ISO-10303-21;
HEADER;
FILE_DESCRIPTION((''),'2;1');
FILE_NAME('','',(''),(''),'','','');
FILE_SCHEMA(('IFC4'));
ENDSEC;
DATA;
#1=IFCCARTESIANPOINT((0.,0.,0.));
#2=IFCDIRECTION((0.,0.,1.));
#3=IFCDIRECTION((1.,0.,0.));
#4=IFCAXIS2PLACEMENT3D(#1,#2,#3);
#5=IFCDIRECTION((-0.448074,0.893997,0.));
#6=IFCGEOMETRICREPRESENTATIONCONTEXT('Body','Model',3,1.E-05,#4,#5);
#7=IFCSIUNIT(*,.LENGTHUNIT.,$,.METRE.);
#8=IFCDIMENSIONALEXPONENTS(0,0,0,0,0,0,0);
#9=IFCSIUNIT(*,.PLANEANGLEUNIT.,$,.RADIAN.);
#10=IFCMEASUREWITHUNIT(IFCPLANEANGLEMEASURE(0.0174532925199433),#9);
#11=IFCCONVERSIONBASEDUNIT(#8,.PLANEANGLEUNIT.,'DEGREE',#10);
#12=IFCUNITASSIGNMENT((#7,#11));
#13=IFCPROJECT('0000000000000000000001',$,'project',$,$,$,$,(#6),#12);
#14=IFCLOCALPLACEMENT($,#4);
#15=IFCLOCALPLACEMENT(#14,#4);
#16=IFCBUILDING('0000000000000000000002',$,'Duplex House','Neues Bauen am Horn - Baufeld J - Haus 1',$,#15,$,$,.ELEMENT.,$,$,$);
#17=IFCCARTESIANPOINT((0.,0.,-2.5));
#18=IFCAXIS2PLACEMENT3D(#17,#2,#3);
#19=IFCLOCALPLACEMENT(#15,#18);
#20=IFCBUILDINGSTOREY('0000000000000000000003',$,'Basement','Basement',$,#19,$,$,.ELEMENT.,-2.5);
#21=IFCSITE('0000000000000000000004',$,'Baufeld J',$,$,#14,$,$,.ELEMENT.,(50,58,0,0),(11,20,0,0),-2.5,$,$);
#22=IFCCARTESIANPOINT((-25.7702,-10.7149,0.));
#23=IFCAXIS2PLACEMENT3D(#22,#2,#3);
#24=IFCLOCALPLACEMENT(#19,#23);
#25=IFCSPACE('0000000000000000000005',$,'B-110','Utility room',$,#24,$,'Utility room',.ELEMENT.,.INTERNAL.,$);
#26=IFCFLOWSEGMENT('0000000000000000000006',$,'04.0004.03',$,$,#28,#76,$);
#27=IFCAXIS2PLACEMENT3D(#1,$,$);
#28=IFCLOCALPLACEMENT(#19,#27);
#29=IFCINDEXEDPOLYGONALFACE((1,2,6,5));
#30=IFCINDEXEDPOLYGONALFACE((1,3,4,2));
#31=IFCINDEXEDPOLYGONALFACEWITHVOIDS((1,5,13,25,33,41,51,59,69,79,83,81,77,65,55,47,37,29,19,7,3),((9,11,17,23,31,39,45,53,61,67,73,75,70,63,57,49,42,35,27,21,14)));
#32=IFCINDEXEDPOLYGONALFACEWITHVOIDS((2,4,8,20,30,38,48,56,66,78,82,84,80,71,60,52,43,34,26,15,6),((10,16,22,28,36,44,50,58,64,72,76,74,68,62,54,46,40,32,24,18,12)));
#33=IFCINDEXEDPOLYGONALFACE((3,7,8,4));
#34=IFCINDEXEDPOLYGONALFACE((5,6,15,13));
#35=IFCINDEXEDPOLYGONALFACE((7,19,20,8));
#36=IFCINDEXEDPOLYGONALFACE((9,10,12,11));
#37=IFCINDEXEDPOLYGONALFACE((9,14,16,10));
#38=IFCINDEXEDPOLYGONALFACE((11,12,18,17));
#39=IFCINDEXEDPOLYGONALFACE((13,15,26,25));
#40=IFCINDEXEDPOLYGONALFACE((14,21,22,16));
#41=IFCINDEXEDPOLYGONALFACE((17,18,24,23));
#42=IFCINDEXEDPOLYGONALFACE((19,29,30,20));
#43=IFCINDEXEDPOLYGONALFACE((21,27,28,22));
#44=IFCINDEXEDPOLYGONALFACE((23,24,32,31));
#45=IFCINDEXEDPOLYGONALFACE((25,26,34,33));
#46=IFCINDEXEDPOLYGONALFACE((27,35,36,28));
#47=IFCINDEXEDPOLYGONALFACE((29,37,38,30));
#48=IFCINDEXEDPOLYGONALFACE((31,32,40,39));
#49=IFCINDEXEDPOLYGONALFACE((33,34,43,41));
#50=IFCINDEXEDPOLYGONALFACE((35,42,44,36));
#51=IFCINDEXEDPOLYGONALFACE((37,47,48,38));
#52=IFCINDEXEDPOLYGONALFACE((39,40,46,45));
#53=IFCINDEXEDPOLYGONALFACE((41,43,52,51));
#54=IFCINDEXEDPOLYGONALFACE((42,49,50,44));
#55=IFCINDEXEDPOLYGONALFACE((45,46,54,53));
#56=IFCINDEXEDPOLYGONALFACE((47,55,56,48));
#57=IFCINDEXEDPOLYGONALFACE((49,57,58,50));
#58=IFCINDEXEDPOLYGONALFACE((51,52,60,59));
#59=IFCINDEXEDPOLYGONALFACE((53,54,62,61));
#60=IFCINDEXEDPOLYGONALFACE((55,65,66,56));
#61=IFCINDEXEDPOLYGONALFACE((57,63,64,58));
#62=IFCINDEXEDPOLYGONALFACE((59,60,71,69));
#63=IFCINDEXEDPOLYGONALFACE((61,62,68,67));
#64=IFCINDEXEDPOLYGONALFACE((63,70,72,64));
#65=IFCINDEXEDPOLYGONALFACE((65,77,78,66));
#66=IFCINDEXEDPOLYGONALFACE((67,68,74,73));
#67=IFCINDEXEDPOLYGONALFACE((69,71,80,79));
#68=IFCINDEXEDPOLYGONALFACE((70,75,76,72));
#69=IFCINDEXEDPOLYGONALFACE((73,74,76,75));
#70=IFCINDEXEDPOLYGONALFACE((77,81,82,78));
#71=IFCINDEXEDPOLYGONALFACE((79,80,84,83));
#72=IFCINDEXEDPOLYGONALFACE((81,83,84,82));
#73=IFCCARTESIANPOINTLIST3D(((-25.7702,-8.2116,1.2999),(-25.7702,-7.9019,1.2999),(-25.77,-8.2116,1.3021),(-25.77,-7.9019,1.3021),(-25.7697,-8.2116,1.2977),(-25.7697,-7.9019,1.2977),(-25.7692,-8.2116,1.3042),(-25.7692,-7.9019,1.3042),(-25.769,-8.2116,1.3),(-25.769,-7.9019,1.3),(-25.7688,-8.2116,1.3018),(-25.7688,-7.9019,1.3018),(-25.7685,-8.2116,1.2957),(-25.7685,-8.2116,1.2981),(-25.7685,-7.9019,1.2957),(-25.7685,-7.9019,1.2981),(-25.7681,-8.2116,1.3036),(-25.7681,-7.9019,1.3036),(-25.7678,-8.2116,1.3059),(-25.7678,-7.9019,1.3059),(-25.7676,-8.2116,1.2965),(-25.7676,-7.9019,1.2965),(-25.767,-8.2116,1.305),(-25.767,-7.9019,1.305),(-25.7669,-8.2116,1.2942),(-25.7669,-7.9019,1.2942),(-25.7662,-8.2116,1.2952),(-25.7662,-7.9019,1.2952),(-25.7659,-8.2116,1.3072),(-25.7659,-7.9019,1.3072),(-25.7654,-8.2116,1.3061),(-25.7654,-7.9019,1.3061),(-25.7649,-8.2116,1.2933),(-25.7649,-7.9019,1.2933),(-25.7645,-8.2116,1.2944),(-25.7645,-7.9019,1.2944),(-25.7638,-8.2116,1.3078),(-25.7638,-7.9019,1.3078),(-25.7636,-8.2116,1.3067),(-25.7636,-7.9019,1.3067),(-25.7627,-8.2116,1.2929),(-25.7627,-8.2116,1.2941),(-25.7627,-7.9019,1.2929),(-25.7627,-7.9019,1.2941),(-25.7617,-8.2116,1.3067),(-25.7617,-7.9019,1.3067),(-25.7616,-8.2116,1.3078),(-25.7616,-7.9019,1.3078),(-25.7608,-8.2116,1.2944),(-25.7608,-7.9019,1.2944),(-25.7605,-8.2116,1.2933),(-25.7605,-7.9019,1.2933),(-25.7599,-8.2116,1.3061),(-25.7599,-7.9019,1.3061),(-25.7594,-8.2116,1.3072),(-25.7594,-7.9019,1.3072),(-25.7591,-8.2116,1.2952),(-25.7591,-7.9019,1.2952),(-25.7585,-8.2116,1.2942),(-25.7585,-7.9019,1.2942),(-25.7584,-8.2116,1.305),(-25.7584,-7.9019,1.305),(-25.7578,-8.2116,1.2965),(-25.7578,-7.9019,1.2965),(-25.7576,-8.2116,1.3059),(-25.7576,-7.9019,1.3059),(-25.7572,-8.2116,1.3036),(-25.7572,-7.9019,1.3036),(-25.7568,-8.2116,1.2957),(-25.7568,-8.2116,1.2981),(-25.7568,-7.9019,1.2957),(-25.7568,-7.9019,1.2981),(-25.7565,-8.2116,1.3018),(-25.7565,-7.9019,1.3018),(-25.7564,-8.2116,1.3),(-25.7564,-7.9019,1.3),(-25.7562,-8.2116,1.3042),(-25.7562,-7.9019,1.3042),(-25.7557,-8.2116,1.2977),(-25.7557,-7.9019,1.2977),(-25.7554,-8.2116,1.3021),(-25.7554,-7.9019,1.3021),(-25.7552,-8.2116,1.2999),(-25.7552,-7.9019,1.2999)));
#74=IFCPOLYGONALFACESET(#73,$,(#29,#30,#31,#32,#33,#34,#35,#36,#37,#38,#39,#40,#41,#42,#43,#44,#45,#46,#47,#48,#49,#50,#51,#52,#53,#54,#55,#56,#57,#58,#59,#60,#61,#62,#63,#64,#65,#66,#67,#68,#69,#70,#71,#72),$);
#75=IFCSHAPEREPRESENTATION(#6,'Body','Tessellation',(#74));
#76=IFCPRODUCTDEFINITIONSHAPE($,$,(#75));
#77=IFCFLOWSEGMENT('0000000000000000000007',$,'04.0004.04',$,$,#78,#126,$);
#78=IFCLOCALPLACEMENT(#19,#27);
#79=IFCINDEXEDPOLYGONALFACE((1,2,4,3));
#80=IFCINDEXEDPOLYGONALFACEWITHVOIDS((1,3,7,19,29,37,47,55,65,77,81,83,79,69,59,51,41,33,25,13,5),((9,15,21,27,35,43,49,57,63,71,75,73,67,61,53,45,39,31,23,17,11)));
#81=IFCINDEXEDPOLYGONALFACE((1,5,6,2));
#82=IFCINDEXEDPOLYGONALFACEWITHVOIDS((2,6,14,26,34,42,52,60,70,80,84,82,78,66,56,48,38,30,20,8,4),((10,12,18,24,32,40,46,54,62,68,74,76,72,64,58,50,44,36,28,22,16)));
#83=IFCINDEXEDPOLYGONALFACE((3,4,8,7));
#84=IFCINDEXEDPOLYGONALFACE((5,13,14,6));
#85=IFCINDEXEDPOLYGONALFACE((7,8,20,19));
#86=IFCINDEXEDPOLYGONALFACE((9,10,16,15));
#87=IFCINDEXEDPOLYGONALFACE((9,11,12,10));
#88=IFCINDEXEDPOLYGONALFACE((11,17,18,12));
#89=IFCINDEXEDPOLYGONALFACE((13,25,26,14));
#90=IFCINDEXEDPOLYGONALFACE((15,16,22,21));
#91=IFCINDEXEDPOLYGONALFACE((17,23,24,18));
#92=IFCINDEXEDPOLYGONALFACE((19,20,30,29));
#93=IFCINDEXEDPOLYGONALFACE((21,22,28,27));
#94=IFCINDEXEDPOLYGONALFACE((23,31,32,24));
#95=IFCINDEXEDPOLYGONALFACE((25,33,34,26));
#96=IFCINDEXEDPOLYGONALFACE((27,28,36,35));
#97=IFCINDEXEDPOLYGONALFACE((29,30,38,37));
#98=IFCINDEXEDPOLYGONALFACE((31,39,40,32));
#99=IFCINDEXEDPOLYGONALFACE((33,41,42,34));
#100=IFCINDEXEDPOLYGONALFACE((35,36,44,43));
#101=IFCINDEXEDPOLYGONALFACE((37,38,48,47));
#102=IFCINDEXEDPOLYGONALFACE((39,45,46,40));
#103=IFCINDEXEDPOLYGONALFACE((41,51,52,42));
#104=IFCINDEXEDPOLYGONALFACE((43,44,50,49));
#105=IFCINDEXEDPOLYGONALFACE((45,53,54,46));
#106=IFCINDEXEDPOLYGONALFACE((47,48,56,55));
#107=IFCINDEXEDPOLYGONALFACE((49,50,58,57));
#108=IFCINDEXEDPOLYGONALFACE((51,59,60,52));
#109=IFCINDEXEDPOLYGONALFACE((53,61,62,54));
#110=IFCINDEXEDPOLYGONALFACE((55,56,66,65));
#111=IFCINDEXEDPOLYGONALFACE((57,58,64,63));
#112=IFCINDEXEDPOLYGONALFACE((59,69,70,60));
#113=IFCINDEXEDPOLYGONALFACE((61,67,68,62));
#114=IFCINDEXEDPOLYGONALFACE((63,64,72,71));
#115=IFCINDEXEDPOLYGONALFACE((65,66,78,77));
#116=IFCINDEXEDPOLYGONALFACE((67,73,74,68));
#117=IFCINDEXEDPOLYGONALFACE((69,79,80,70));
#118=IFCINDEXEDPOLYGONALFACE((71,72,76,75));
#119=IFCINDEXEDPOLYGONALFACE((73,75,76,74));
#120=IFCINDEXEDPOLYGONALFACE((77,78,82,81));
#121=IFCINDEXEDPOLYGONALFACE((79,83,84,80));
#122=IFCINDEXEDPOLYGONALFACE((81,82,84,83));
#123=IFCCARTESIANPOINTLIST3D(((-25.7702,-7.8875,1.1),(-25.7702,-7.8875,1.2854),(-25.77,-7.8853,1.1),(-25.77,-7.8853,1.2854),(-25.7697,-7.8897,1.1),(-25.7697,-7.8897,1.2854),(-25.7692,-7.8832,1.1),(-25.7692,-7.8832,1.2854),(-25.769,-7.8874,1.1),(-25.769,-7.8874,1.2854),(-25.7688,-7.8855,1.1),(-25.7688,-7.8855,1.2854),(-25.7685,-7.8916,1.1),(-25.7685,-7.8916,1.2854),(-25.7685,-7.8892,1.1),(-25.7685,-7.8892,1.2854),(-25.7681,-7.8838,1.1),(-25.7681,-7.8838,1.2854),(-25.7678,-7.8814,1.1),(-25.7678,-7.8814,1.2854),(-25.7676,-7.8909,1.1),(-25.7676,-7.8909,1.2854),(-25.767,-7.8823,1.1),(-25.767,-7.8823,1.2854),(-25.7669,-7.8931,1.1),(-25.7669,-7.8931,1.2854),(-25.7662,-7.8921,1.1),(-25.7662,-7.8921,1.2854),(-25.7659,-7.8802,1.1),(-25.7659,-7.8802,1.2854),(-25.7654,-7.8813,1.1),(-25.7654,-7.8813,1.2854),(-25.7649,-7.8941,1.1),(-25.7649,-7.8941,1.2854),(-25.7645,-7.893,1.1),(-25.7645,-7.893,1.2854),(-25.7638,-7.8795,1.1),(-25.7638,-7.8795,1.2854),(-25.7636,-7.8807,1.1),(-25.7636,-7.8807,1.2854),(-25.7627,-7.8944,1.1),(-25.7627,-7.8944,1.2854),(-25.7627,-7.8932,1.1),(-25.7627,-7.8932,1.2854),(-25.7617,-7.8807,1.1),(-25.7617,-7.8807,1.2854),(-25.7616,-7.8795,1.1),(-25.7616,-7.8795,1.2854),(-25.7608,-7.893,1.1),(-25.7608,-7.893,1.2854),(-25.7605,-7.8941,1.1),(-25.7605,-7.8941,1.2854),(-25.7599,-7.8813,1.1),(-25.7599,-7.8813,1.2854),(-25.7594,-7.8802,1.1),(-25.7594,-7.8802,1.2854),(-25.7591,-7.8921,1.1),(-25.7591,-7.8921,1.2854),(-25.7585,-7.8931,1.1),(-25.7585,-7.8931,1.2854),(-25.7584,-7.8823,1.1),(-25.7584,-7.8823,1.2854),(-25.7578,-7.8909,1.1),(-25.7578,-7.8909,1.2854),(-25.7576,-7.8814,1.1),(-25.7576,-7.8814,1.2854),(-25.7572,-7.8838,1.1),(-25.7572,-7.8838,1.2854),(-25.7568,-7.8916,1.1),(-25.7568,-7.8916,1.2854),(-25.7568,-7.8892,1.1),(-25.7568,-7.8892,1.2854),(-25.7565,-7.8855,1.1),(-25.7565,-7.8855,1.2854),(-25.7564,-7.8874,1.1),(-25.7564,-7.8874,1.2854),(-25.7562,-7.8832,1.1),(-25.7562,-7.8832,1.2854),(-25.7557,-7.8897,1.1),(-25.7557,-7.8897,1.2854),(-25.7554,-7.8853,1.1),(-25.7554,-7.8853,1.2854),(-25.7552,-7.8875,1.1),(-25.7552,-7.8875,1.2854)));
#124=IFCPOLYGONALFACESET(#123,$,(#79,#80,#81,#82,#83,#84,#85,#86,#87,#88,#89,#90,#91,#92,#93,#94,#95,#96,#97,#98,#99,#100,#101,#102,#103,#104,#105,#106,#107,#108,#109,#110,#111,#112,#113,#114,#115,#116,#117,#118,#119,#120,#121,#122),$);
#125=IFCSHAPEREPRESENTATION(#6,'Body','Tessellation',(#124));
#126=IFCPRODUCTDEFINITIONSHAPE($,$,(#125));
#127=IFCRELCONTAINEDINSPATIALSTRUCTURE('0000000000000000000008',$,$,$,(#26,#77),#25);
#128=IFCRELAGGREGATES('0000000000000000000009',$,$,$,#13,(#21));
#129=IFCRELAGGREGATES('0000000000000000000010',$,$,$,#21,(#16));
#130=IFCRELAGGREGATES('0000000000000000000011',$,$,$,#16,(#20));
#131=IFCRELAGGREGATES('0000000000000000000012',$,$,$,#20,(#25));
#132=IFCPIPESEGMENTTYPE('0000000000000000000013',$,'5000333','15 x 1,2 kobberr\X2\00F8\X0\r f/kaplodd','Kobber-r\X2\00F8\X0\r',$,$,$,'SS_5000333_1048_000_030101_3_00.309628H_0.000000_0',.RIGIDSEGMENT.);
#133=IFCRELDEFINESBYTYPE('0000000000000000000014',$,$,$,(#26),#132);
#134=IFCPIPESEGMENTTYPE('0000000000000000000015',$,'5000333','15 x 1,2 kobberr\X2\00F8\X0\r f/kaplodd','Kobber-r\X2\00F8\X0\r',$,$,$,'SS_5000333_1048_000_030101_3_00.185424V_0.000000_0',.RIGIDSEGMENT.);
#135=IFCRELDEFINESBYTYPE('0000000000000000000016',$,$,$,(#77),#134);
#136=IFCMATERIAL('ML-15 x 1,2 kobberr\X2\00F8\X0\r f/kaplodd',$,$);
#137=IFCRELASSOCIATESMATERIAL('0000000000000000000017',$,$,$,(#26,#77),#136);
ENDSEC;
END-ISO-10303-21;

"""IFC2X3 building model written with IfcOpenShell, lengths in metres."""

from ifc_helpers import new_model, entity, si_unit, converted_unit, direction, frame, origin_with_axes, origin_2d_with_axis, place, context, project, spatial, hollow_circle, extrude, material, type_object, element, save


model = new_model("IFC2X3")

# Units and contexts
model_context = context("Model", 3, precision=1e-05, world=origin_with_axes(), true_north=direction((-0.448074, 0.893997, 0.0)), identifier="Body")
ifc_project = project(units=[si_unit("LENGTHUNIT", "METRE"), converted_unit("PLANEANGLEUNIT", "DEGREE", entity("IfcPlaneAngleMeasure", 0.0174532925199433), si_unit("PLANEANGLEUNIT", "RADIAN"), dimensions=[0, 0, 0, 0, 0, 0, 0])], contexts=[model_context])

# Site, building, storey, space
site_placement = place(None, origin_with_axes())
site = spatial("IfcSite", under=ifc_project, at=site_placement, Name="Baufeld J", CompositionType="ELEMENT", RefLatitude=(50, 58, 0, 0), RefLongitude=(11, 20, 0, 0), RefElevation=-2.5)
building_placement = place(site_placement, origin_with_axes())
building = spatial("IfcBuilding", under=site, at=building_placement, Name="Duplex House", Description="Neues Bauen am Horn - Baufeld J - Haus 1", CompositionType="ELEMENT")
storey_placement = place(building_placement, frame((0.0, 0.0, -2.5), z_axis=(0.0, 0.0, 1.0), x_axis=(1.0, 0.0, 0.0)))
storey = spatial("IfcBuildingStorey", under=building, at=storey_placement, Name="Basement", Description="Basement", CompositionType="ELEMENT", Elevation=-2.5)
space_1_placement = place(storey_placement, frame((-25.7702, -10.7149, 0.0), z_axis=(0.0, 0.0, 1.0), x_axis=(1.0, 0.0, 0.0)))
space_1 = spatial("IfcSpace", under=storey, at=space_1_placement, Name="B-110", Description="Utility room", LongName="Utility room", CompositionType="ELEMENT", InteriorOrExteriorSpace="INTERNAL")

# Shared definitions
ifc_material_1 = material(Name="ML-15 x 1,2 kobberrør f/kaplodd")

# Flow segments
pipe_segment_type_1 = type_object("IfcPipeSegmentType", Name="5000333", Description="15 x 1,2 kobberrør f/kaplodd", ApplicableOccurrence="Kobber-rør", ElementType="SS_5000333_1048_000_030101_3_00.309628H_0.000000_0", PredefinedType="RIGIDSEGMENT")
flow_segment_1_placement = place(space_1_placement, frame((0.0075, 2.5034, 1.3004), z_axis=(0.0, 0.0, 1.0), x_axis=(0.0, 1.0, 0.0)))
element("IfcFlowSegment", 1, at=flow_segment_1_placement, inside=space_1, type_object=pipe_segment_type_1, material=ifc_material_1, Name="04.0004.03", context=model_context, shape_type="SweptSolid", body=[
    extrude(hollow_circle(Radius=0.0075, WallThickness=0.0012, at=origin_2d_with_axis()), frame((0.0, 0.0, 0.0), z_axis=(1.0, 0.0, 0.0), x_axis=(0.0, 0.0, -1.0)), (0.0, 0.0, 1.0), 0.3096),
])
pipe_segment_type_2 = type_object("IfcPipeSegmentType", Name="5000333", Description="15 x 1,2 kobberrør f/kaplodd", ApplicableOccurrence="Kobber-rør", ElementType="SS_5000333_1048_000_030101_3_00.185424V_0.000000_0", PredefinedType="RIGIDSEGMENT")
flow_segment_2_placement = place(space_1_placement, frame((0.0075, 2.828, 1.2854), z_axis=(0.0, 1.0, 0.0), x_axis=(0.0, 0.0, -1.0)))
element("IfcFlowSegment", 2, at=flow_segment_2_placement, inside=space_1, type_object=pipe_segment_type_2, material=ifc_material_1, Name="04.0004.04", context=model_context, shape_type="SweptSolid", body=[
    extrude(hollow_circle(Radius=0.0075, WallThickness=0.0012, at=origin_2d_with_axis()), frame((0.0, 0.0, 0.0), z_axis=(1.0, 0.0, 0.0), x_axis=(0.0, 0.0, -1.0)), (0.0, 0.0, 1.0), 0.1854),
])

save(model, "model.ifc")
